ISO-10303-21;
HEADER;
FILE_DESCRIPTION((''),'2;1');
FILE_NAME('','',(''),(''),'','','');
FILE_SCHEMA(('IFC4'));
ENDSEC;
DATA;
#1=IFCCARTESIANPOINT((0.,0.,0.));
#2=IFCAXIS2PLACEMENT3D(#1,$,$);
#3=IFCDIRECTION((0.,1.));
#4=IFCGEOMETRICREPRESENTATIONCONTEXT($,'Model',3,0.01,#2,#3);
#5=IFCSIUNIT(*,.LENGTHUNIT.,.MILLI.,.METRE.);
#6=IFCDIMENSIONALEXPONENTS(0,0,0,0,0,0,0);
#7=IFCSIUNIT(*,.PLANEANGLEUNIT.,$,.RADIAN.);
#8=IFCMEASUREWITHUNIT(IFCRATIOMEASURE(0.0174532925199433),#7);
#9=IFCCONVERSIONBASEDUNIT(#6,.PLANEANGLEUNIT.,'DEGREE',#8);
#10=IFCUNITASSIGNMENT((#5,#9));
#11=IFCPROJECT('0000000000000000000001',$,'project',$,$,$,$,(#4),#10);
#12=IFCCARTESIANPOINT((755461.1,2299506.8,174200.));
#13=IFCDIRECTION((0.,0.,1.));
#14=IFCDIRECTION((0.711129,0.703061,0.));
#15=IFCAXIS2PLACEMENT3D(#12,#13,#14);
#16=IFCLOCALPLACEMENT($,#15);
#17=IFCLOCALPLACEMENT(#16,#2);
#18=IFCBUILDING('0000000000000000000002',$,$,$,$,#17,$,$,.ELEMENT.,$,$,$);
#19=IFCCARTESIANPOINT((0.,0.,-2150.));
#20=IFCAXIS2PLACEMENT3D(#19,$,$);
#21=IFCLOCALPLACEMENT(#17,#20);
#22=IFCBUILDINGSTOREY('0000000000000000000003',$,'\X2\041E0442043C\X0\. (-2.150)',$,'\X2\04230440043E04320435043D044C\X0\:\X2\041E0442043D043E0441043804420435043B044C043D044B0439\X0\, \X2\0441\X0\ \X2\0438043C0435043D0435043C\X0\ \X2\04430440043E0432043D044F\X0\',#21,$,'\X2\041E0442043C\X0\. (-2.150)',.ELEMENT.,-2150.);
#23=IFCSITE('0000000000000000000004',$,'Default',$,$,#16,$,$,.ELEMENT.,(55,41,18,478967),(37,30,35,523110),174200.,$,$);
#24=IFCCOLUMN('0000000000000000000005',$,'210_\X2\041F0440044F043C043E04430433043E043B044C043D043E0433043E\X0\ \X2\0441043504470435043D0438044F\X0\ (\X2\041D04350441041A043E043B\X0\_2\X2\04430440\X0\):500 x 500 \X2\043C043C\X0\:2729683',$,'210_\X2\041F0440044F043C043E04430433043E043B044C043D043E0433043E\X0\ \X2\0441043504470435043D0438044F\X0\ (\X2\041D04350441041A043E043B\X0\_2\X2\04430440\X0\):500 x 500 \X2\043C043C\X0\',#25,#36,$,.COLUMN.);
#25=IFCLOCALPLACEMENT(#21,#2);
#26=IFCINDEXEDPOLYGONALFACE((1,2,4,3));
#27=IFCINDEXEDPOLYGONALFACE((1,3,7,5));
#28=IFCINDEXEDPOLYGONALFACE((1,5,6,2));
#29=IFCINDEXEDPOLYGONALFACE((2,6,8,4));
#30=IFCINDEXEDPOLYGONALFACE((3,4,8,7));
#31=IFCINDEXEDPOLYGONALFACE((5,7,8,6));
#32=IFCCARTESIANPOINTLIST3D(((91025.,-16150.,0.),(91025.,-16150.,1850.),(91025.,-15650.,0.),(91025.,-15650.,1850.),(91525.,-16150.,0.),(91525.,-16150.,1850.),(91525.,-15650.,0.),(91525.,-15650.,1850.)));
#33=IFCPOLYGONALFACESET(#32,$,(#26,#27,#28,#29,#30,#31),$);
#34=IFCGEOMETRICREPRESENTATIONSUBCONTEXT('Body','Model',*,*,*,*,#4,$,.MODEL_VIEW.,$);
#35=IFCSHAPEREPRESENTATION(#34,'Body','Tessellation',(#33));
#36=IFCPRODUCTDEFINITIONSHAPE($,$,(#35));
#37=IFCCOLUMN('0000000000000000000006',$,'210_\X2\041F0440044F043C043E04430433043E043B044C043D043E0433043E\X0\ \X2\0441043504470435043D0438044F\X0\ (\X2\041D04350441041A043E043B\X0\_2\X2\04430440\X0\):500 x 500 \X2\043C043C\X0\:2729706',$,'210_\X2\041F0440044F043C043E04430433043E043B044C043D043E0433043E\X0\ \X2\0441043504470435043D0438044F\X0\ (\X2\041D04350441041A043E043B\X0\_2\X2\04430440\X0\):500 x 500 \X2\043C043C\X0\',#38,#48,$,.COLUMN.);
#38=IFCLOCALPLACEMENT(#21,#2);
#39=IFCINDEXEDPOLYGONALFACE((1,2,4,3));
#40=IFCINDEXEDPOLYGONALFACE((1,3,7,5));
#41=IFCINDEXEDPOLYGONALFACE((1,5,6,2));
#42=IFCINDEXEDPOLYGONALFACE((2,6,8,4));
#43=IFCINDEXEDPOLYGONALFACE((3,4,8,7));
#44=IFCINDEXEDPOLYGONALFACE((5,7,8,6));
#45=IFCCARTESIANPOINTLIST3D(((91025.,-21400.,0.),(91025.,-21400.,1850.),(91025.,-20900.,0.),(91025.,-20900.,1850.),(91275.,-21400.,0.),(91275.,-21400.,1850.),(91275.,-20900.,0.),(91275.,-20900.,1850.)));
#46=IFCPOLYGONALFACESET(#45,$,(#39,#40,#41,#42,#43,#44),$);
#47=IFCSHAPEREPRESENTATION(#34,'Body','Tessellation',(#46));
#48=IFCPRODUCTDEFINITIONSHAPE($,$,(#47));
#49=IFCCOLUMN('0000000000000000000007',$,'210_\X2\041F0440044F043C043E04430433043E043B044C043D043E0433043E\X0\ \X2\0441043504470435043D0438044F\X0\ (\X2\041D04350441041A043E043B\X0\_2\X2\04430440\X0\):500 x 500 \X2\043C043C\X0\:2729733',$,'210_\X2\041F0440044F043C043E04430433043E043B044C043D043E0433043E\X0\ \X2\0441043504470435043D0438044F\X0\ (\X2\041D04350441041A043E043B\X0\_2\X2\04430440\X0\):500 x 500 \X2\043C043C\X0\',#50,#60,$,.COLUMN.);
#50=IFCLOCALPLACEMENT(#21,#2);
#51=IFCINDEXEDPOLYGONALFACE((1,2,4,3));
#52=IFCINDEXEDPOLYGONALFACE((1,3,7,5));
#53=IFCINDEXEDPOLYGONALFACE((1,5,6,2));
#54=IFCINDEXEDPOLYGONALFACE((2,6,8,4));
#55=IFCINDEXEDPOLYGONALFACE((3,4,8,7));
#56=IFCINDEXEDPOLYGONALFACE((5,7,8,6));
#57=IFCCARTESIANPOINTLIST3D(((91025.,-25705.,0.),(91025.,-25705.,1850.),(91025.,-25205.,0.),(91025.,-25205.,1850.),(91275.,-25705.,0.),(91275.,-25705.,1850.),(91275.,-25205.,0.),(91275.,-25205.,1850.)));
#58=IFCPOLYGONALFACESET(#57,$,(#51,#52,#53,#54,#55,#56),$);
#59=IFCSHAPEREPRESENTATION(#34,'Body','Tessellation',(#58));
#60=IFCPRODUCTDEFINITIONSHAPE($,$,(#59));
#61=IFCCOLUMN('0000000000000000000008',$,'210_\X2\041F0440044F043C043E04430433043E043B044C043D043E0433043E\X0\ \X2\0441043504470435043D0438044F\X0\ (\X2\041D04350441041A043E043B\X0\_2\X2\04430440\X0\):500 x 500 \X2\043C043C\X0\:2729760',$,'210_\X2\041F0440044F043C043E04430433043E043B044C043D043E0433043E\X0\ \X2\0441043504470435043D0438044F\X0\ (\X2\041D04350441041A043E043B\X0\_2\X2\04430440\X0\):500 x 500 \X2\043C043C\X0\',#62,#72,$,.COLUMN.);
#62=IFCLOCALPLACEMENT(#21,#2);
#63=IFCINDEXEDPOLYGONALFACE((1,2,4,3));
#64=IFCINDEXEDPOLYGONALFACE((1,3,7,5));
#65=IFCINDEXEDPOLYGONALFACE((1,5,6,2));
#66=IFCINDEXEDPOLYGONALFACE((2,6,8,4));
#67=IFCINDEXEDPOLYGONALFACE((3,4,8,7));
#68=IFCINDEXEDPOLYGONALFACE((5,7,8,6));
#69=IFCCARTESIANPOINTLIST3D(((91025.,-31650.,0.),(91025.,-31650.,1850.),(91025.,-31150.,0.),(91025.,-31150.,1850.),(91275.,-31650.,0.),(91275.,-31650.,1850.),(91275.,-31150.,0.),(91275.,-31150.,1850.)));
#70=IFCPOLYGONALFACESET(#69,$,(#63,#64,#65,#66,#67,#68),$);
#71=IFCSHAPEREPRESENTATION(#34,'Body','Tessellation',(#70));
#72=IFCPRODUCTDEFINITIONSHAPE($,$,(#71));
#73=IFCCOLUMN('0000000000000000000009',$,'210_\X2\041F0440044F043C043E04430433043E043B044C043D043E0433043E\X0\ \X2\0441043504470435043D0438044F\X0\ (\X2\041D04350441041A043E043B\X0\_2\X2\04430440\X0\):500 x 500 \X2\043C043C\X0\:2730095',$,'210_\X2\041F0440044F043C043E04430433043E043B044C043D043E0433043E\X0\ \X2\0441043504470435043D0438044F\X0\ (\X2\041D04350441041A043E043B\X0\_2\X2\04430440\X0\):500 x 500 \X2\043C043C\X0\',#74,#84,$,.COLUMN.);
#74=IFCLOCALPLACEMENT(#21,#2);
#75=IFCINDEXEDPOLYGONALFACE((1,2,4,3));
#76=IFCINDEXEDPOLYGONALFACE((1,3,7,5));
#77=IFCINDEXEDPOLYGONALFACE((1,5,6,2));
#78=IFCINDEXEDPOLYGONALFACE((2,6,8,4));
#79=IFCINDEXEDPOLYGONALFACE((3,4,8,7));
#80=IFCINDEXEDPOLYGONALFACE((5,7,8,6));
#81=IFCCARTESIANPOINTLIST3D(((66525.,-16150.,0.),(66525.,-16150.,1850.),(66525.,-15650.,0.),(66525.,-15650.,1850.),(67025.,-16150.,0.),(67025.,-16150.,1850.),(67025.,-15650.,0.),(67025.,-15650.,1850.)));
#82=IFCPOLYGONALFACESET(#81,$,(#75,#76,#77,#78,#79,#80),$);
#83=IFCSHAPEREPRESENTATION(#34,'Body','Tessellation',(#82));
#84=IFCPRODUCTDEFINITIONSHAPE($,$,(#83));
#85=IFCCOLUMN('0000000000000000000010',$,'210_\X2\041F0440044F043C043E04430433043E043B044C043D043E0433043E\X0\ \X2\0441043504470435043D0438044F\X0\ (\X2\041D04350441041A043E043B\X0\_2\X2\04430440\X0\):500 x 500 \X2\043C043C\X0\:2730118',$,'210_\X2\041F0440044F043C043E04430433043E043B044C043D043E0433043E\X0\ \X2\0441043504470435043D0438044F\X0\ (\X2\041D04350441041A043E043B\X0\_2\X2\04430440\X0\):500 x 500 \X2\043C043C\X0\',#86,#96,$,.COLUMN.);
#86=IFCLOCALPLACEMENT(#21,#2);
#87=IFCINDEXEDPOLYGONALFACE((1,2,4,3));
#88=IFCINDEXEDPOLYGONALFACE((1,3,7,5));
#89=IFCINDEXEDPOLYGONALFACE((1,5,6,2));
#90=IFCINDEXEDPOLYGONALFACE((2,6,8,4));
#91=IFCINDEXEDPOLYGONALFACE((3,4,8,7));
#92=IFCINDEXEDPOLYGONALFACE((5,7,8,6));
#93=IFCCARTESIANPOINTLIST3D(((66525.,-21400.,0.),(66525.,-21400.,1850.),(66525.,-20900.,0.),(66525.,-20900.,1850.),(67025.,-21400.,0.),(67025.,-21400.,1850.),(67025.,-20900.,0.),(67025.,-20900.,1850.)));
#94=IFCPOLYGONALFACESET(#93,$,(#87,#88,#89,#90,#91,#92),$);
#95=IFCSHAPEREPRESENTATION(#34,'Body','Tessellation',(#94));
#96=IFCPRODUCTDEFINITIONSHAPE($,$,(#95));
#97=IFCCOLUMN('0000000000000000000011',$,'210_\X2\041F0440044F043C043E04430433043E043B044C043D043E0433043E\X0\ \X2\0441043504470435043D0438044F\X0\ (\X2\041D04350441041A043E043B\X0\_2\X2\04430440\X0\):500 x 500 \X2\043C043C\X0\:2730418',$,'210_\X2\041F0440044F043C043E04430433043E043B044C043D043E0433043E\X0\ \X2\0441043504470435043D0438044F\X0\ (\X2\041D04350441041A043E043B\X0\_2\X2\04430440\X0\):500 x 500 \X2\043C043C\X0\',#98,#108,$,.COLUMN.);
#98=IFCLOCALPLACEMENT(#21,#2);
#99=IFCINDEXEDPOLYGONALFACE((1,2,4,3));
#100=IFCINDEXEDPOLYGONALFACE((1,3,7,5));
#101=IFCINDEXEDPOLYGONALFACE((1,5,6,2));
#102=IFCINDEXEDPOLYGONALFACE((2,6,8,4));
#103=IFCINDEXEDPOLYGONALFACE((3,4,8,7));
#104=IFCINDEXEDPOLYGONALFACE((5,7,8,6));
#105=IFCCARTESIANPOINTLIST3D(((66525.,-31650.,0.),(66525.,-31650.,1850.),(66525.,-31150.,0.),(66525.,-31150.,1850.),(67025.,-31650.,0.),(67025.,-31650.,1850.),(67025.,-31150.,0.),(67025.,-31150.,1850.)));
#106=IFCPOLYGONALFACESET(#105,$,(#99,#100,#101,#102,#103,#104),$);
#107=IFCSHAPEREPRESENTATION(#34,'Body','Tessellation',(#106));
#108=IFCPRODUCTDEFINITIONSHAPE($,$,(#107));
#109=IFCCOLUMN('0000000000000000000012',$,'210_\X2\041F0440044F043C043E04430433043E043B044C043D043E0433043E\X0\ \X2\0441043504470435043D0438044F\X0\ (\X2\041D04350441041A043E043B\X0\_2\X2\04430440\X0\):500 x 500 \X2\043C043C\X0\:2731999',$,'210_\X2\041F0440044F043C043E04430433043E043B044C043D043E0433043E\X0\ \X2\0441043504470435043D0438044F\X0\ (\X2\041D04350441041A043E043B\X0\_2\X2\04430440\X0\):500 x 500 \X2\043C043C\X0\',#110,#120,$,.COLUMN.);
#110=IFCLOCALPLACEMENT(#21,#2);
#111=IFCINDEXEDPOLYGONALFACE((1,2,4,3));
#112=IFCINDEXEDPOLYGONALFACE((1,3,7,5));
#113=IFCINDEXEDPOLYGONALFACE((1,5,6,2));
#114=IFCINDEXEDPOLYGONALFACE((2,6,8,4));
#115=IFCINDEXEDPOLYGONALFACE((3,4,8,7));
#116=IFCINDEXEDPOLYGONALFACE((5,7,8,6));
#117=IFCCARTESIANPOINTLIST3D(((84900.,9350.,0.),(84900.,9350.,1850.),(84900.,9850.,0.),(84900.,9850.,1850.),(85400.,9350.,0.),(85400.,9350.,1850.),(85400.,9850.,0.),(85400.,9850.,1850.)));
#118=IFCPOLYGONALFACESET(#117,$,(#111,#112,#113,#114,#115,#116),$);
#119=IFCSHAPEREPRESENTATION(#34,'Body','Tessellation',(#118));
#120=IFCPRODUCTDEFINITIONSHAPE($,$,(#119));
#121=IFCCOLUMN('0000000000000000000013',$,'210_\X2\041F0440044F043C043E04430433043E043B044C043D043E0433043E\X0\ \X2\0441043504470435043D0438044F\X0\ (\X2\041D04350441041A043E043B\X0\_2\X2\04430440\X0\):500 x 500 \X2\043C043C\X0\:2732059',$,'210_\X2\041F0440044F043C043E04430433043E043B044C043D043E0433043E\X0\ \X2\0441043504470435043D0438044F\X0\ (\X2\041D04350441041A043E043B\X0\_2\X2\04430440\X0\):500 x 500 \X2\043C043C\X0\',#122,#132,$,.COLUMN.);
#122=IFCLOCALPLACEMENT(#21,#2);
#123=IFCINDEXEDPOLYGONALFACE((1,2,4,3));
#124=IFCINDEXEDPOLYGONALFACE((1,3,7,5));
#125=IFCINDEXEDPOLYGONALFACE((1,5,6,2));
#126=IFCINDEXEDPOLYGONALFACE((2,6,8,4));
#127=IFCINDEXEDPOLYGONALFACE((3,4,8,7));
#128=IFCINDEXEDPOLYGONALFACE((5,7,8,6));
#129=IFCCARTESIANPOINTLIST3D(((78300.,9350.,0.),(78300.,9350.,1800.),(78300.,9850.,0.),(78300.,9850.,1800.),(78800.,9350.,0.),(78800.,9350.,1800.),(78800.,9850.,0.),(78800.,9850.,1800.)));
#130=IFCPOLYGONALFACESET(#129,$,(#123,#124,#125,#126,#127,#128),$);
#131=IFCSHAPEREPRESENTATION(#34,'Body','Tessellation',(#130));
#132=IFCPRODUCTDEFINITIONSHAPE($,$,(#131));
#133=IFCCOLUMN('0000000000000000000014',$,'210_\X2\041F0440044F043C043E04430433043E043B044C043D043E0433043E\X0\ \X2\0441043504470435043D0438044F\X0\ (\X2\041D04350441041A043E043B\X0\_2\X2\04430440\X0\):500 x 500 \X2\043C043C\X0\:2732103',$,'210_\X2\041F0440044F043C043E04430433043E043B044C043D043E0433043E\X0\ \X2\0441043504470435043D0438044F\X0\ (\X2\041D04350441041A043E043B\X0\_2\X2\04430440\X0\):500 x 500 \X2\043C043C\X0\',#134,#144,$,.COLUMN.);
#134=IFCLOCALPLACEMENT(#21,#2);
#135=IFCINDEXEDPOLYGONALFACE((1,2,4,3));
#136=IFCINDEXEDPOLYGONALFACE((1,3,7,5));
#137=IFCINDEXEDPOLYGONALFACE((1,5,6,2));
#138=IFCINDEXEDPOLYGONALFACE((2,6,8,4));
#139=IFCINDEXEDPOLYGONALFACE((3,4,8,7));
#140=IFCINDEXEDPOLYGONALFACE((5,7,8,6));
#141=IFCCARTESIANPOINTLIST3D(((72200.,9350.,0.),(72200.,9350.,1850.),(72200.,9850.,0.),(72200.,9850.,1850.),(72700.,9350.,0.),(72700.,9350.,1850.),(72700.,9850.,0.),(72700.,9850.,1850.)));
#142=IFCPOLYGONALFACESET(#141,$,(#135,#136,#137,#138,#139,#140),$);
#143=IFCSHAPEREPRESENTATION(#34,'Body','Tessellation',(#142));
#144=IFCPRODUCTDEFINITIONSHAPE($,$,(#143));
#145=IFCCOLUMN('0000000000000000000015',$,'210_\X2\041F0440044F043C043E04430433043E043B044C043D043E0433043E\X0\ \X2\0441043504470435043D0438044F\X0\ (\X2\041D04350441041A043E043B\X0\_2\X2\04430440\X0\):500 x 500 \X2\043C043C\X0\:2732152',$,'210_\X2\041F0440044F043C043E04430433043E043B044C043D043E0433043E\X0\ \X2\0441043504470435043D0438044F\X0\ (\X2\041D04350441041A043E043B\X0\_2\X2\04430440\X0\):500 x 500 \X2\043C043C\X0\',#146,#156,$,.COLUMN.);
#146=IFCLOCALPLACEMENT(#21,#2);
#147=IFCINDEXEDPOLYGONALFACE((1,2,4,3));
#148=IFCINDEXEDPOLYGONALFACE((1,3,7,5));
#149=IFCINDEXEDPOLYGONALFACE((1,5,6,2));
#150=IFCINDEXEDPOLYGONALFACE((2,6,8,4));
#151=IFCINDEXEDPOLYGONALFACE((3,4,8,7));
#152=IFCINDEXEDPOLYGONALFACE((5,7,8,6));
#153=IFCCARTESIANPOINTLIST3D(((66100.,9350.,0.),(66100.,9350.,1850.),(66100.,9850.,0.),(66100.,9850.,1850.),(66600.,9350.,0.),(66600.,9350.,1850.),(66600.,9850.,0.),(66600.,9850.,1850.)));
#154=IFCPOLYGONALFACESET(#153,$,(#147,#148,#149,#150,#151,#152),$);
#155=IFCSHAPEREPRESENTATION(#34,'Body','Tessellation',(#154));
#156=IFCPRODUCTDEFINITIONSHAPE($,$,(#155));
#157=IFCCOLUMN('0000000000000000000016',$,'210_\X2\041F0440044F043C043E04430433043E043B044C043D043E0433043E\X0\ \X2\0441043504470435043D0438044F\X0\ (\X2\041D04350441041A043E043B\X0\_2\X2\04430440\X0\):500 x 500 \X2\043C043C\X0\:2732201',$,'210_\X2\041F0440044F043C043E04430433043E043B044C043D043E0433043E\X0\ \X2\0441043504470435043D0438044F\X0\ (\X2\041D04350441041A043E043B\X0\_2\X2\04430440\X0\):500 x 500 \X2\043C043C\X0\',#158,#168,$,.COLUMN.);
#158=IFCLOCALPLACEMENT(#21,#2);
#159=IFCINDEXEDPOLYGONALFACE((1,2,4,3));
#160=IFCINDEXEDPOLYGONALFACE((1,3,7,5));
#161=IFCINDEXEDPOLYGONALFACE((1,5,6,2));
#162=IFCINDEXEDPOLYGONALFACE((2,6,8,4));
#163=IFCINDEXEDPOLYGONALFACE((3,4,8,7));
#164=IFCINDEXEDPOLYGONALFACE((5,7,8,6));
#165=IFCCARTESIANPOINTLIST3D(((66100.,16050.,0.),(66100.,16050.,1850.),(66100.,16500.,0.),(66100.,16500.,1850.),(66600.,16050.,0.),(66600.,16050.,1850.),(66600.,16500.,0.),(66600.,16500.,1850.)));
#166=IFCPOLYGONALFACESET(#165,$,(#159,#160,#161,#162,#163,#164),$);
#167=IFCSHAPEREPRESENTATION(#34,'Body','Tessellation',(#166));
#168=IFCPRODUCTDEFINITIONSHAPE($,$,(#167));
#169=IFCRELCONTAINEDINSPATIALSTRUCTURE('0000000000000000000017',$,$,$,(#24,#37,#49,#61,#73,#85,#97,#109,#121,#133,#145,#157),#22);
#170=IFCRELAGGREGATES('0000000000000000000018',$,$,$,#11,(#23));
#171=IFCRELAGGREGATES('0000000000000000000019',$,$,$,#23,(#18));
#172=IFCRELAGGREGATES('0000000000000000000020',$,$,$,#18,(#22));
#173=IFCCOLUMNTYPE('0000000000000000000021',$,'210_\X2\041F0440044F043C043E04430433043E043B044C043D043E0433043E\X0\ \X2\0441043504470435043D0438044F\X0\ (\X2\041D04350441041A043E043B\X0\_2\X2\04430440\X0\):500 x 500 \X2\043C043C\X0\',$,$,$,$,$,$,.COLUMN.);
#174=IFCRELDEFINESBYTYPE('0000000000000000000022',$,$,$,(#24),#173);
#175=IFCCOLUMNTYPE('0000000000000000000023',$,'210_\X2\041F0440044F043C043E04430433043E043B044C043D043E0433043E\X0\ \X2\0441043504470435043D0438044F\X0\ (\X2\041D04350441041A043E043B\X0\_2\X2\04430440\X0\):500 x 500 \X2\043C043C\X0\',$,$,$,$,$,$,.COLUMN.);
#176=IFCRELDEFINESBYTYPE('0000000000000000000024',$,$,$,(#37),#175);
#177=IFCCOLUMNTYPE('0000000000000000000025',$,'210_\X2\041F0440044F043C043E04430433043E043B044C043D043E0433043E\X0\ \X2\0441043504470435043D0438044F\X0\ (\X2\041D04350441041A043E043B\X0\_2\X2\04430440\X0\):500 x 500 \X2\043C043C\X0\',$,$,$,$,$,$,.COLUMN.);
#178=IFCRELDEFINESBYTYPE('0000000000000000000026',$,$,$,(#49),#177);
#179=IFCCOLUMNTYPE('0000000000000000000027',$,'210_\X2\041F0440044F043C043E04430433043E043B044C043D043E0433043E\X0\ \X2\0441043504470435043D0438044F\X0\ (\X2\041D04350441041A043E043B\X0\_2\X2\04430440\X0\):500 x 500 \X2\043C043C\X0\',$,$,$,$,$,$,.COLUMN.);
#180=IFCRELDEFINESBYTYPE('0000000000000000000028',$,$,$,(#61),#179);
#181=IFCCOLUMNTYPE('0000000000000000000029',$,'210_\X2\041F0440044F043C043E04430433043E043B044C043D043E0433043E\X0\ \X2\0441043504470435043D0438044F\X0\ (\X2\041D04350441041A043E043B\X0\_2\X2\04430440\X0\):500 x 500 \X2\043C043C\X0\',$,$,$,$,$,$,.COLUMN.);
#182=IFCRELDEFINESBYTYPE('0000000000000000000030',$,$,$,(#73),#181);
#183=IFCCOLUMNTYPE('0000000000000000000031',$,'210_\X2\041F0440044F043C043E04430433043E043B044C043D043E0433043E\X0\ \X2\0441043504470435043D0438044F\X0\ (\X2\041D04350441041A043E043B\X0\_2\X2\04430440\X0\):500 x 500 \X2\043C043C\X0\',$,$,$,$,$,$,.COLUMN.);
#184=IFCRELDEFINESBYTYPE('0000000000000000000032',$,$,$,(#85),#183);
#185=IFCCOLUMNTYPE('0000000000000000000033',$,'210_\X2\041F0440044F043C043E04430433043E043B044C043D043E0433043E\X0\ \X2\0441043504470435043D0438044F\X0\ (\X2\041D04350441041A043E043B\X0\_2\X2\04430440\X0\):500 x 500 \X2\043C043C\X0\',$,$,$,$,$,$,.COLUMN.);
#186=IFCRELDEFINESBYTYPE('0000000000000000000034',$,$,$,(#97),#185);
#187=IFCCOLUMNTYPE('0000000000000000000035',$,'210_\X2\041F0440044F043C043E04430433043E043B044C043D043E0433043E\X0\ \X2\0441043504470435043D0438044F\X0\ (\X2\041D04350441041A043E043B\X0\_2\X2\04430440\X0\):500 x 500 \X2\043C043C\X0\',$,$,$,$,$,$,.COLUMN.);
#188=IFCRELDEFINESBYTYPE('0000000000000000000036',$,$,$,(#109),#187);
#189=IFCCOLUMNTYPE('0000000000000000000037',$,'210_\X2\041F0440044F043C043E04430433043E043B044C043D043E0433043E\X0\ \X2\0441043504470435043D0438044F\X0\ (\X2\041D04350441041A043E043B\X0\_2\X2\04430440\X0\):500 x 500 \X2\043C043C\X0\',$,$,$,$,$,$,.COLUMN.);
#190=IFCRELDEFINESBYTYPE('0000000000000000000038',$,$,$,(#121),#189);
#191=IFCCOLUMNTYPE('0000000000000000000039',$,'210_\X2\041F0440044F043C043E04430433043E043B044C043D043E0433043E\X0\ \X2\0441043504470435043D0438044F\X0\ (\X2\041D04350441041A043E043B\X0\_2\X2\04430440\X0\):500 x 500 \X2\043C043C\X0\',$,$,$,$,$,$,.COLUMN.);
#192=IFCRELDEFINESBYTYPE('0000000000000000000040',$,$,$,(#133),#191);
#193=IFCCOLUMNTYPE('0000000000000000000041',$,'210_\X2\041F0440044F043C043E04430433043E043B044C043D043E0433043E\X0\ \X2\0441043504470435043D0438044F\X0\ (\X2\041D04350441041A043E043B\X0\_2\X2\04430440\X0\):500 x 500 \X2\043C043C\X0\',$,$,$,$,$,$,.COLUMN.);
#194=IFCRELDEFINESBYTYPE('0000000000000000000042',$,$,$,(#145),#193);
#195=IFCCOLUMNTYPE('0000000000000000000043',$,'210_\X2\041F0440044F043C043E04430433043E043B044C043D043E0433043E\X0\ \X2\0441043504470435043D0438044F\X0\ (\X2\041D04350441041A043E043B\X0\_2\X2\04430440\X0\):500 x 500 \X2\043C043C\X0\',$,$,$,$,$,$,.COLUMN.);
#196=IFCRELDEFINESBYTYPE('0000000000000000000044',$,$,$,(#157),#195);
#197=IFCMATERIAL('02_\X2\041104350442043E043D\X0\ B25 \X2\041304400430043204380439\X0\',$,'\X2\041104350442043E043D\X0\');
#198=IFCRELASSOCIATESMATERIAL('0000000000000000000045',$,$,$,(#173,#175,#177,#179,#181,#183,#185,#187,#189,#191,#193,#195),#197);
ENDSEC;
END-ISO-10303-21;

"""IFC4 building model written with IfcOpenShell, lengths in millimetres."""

from ifc_helpers import new_model, entity, si_unit, converted_unit, direction, frame, origin, place, context, subcontext, project, spatial, indexed_curve, outline, extrude, source, transform, mapped, material, type_object, type_shapes, element, save


model = new_model("IFC4")

# Units and contexts
model_context = context("Model", 3, precision=0.01, world=origin(), true_north=direction((0.0, 1.0)))
body_context = subcontext(model_context, "Body", "Model", "MODEL_VIEW")
ifc_project = project(units=[si_unit("LENGTHUNIT", "METRE", prefix="MILLI"), converted_unit("PLANEANGLEUNIT", "DEGREE", entity("IfcRatioMeasure", 0.0174532925199433), si_unit("PLANEANGLEUNIT", "RADIAN"), dimensions=[0, 0, 0, 0, 0, 0, 0])], contexts=[model_context])

# Site, building, storey
site_placement = place(None, frame((755461.1, 2299506.8, 174200.0), z_axis=(0.0, 0.0, 1.0), x_axis=(0.711129, 0.703061, 0.0)))
site = spatial("IfcSite", under=ifc_project, at=site_placement, Name="Default", CompositionType="ELEMENT", RefLatitude=(55, 41, 18, 478967), RefLongitude=(37, 30, 35, 523110), RefElevation=174200.0)
building_placement = place(site_placement, origin())
building = spatial("IfcBuilding", under=site, at=building_placement, CompositionType="ELEMENT")
storey_placement = place(building_placement, frame((0.0, 0.0, -2150.0)))
storey = spatial("IfcBuildingStorey", under=building, at=storey_placement, Name="Отм. (-2.150)", ObjectType="Уровень:Относительный, с именем уровня", LongName="Отм. (-2.150)", CompositionType="ELEMENT", Elevation=-2150.0)

# Columns
ifc_material_1 = material(Name="02_Бетон B25 Гравий", Category="Бетон")
column_type_1 = type_object("IfcColumnType", Name="210_Прямоугольного сечения (НесКол_2ур):500 x 500 мм", PredefinedType="COLUMN", material=ifc_material_1)
shared_shape_1 = source(origin(), body_context, "Body", "SweptSolid", [
    extrude(outline(indexed_curve([(-250.0, -250.0), (250.0, -250.0), (250.0, 250.0), (-250.0, 250.0), (-250.0, -250.0)], self_intersect=False)), frame((91275.0, -15900.0, -2150.0), z_axis=(0.0, 0.0, 1.0), x_axis=(0.0, -1.0, 0.0)), (0.0, 0.0, 1.0), 1850.0),
])
type_shapes(column_type_1, [shared_shape_1])
column_1_placement = place(storey_placement, frame((0.0, 0.0, 2150.0)))
element("IfcColumn", 1, at=column_1_placement, inside=storey, type_object=column_type_1, Name="210_Прямоугольного сечения (НесКол_2ур):500 x 500 мм:2729683", ObjectType="210_Прямоугольного сечения (НесКол_2ур):500 x 500 мм", PredefinedType="COLUMN", context=body_context, shape_type="MappedRepresentation", body=[
    mapped(shared_shape_1, transform((0.0, 0.0, 0.0), scale=1.0)),
])
column_type_2 = type_object("IfcColumnType", Name="210_Прямоугольного сечения (НесКол_2ур):500 x 500 мм", PredefinedType="COLUMN", material=ifc_material_1)
shared_shape_2 = source(origin(), body_context, "Body", "SweptSolid", [
    extrude(outline(indexed_curve([(-250.0, -125.0), (250.0, -125.0), (250.0, 125.0), (-250.0, 125.0), (-250.0, -125.0)], self_intersect=False)), frame((91150.0, -21150.0, -2150.0), z_axis=(0.0, 0.0, 1.0), x_axis=(0.0, -1.0, 0.0)), (0.0, 0.0, 1.0), 1850.0),
])
type_shapes(column_type_2, [shared_shape_2])
column_2_placement = place(storey_placement, frame((0.0, 0.0, 2150.0)))
element("IfcColumn", 2, at=column_2_placement, inside=storey, type_object=column_type_2, Name="210_Прямоугольного сечения (НесКол_2ур):500 x 500 мм:2729706", ObjectType="210_Прямоугольного сечения (НесКол_2ур):500 x 500 мм", PredefinedType="COLUMN", context=body_context, shape_type="MappedRepresentation", body=[
    mapped(shared_shape_2, transform((0.0, 0.0, 0.0), scale=1.0)),
])
column_type_3 = type_object("IfcColumnType", Name="210_Прямоугольного сечения (НесКол_2ур):500 x 500 мм", PredefinedType="COLUMN", material=ifc_material_1)
shared_shape_3 = source(origin(), body_context, "Body", "SweptSolid", [
    extrude(outline(indexed_curve([(-250.0, -125.0), (250.0, -125.0), (250.0, 125.0), (-250.0, 125.0), (-250.0, -125.0)], self_intersect=False)), frame((91150.0, -25455.0, -2150.0), z_axis=(0.0, 0.0, 1.0), x_axis=(0.0, -1.0, 0.0)), (0.0, 0.0, 1.0), 1850.0),
])
type_shapes(column_type_3, [shared_shape_3])
column_3_placement = place(storey_placement, frame((0.0, 0.0, 2150.0)))
element("IfcColumn", 3, at=column_3_placement, inside=storey, type_object=column_type_3, Name="210_Прямоугольного сечения (НесКол_2ур):500 x 500 мм:2729733", ObjectType="210_Прямоугольного сечения (НесКол_2ур):500 x 500 мм", PredefinedType="COLUMN", context=body_context, shape_type="MappedRepresentation", body=[
    mapped(shared_shape_3, transform((0.0, 0.0, 0.0), scale=1.0)),
])
column_type_4 = type_object("IfcColumnType", Name="210_Прямоугольного сечения (НесКол_2ур):500 x 500 мм", PredefinedType="COLUMN", material=ifc_material_1)
shared_shape_4 = source(origin(), body_context, "Body", "SweptSolid", [
    extrude(outline(indexed_curve([(-250.0, -125.0), (250.0, -125.0), (250.0, 125.0), (-250.0, 125.0), (-250.0, -125.0)], self_intersect=False)), frame((91150.0, -31400.0, -2150.0), z_axis=(0.0, 0.0, 1.0), x_axis=(0.0, -1.0, 0.0)), (0.0, 0.0, 1.0), 1850.0),
])
type_shapes(column_type_4, [shared_shape_4])
column_4_placement = place(storey_placement, frame((0.0, 0.0, 2150.0)))
element("IfcColumn", 4, at=column_4_placement, inside=storey, type_object=column_type_4, Name="210_Прямоугольного сечения (НесКол_2ур):500 x 500 мм:2729760", ObjectType="210_Прямоугольного сечения (НесКол_2ур):500 x 500 мм", PredefinedType="COLUMN", context=body_context, shape_type="MappedRepresentation", body=[
    mapped(shared_shape_4, transform((0.0, 0.0, 0.0), scale=1.0)),
])
column_type_5 = type_object("IfcColumnType", Name="210_Прямоугольного сечения (НесКол_2ур):500 x 500 мм", PredefinedType="COLUMN", material=ifc_material_1)
shared_shape_5 = source(origin(), body_context, "Body", "SweptSolid", [
    extrude(outline(indexed_curve([(-250.0, -250.0), (250.0, -250.0), (250.0, 250.0), (-250.0, 250.0), (-250.0, -250.0)], self_intersect=False)), frame((66775.0, -15900.0, -2150.0), z_axis=(0.0, 0.0, 1.0), x_axis=(0.0, -1.0, 0.0)), (0.0, 0.0, 1.0), 1850.0),
])
type_shapes(column_type_5, [shared_shape_5])
column_5_placement = place(storey_placement, frame((0.0, 0.0, 2150.0)))
element("IfcColumn", 5, at=column_5_placement, inside=storey, type_object=column_type_5, Name="210_Прямоугольного сечения (НесКол_2ур):500 x 500 мм:2730095", ObjectType="210_Прямоугольного сечения (НесКол_2ур):500 x 500 мм", PredefinedType="COLUMN", context=body_context, shape_type="MappedRepresentation", body=[
    mapped(shared_shape_5, transform((0.0, 0.0, 0.0), scale=1.0)),
])
column_type_6 = type_object("IfcColumnType", Name="210_Прямоугольного сечения (НесКол_2ур):500 x 500 мм", PredefinedType="COLUMN", material=ifc_material_1)
shared_shape_6 = source(origin(), body_context, "Body", "SweptSolid", [
    extrude(outline(indexed_curve([(-250.0, -250.0), (250.0, -250.0), (250.0, 250.0), (-250.0, 250.0), (-250.0, -250.0)], self_intersect=False)), frame((66775.0, -21150.0, -2150.0), z_axis=(0.0, 0.0, 1.0), x_axis=(0.0, -1.0, 0.0)), (0.0, 0.0, 1.0), 1850.0),
])
type_shapes(column_type_6, [shared_shape_6])
column_6_placement = place(storey_placement, frame((0.0, 0.0, 2150.0)))
element("IfcColumn", 6, at=column_6_placement, inside=storey, type_object=column_type_6, Name="210_Прямоугольного сечения (НесКол_2ур):500 x 500 мм:2730118", ObjectType="210_Прямоугольного сечения (НесКол_2ур):500 x 500 мм", PredefinedType="COLUMN", context=body_context, shape_type="MappedRepresentation", body=[
    mapped(shared_shape_6, transform((0.0, 0.0, 0.0), scale=1.0)),
])
column_type_7 = type_object("IfcColumnType", Name="210_Прямоугольного сечения (НесКол_2ур):500 x 500 мм", PredefinedType="COLUMN", material=ifc_material_1)
shared_shape_7 = source(origin(), body_context, "Body", "SweptSolid", [
    extrude(outline(indexed_curve([(-250.0, -250.0), (250.0, -250.0), (250.0, 250.0), (-250.0, 250.0), (-250.0, -250.0)], self_intersect=False)), frame((66775.0, -31400.0, -2150.0), z_axis=(0.0, 0.0, 1.0), x_axis=(0.0, -1.0, 0.0)), (0.0, 0.0, 1.0), 1850.0),
])
type_shapes(column_type_7, [shared_shape_7])
column_7_placement = place(storey_placement, frame((0.0, 0.0, 2150.0)))
element("IfcColumn", 7, at=column_7_placement, inside=storey, type_object=column_type_7, Name="210_Прямоугольного сечения (НесКол_2ур):500 x 500 мм:2730418", ObjectType="210_Прямоугольного сечения (НесКол_2ур):500 x 500 мм", PredefinedType="COLUMN", context=body_context, shape_type="MappedRepresentation", body=[
    mapped(shared_shape_7, transform((0.0, 0.0, 0.0), scale=1.0)),
])
column_type_8 = type_object("IfcColumnType", Name="210_Прямоугольного сечения (НесКол_2ур):500 x 500 мм", PredefinedType="COLUMN", material=ifc_material_1)
shared_shape_8 = source(origin(), body_context, "Body", "SweptSolid", [
    extrude(outline(indexed_curve([(-250.0, -250.0), (250.0, -250.0), (250.0, 250.0), (-250.0, 250.0), (-250.0, -250.0)], self_intersect=False)), frame((85150.0, 9600.0, -2150.0), z_axis=(0.0, 0.0, 1.0), x_axis=(0.0, -1.0, 0.0)), (0.0, 0.0, 1.0), 1850.0),
])
type_shapes(column_type_8, [shared_shape_8])
column_8_placement = place(storey_placement, frame((0.0, 0.0, 2150.0)))
element("IfcColumn", 8, at=column_8_placement, inside=storey, type_object=column_type_8, Name="210_Прямоугольного сечения (НесКол_2ур):500 x 500 мм:2731999", ObjectType="210_Прямоугольного сечения (НесКол_2ур):500 x 500 мм", PredefinedType="COLUMN", context=body_context, shape_type="MappedRepresentation", body=[
    mapped(shared_shape_8, transform((0.0, 0.0, 0.0), scale=1.0)),
])
column_type_9 = type_object("IfcColumnType", Name="210_Прямоугольного сечения (НесКол_2ур):500 x 500 мм", PredefinedType="COLUMN", material=ifc_material_1)
shared_shape_9 = source(origin(), body_context, "Body", "SweptSolid", [
    extrude(outline(indexed_curve([(-250.0, -250.0), (250.0, -250.0), (250.0, 250.0), (-250.0, 250.0), (-250.0, -250.0)], self_intersect=False)), frame((78550.0, 9600.0, -2150.0), z_axis=(0.0, 0.0, 1.0), x_axis=(0.0, -1.0, 0.0)), (0.0, 0.0, 1.0), 1800.0),
])
type_shapes(column_type_9, [shared_shape_9])
column_9_placement = place(storey_placement, frame((0.0, 0.0, 2150.0)))
element("IfcColumn", 9, at=column_9_placement, inside=storey, type_object=column_type_9, Name="210_Прямоугольного сечения (НесКол_2ур):500 x 500 мм:2732059", ObjectType="210_Прямоугольного сечения (НесКол_2ур):500 x 500 мм", PredefinedType="COLUMN", context=body_context, shape_type="MappedRepresentation", body=[
    mapped(shared_shape_9, transform((0.0, 0.0, 0.0), scale=1.0)),
])
column_type_10 = type_object("IfcColumnType", Name="210_Прямоугольного сечения (НесКол_2ур):500 x 500 мм", PredefinedType="COLUMN", material=ifc_material_1)
shared_shape_10 = source(origin(), body_context, "Body", "SweptSolid", [
    extrude(outline(indexed_curve([(-250.0, -250.0), (250.0, -250.0), (250.0, 250.0), (-250.0, 250.0), (-250.0, -250.0)], self_intersect=False)), frame((72450.0, 9600.0, -2150.0), z_axis=(0.0, 0.0, 1.0), x_axis=(0.0, -1.0, 0.0)), (0.0, 0.0, 1.0), 1850.0),
])
type_shapes(column_type_10, [shared_shape_10])
column_10_placement = place(storey_placement, frame((0.0, 0.0, 2150.0)))
element("IfcColumn", 10, at=column_10_placement, inside=storey, type_object=column_type_10, Name="210_Прямоугольного сечения (НесКол_2ур):500 x 500 мм:2732103", ObjectType="210_Прямоугольного сечения (НесКол_2ур):500 x 500 мм", PredefinedType="COLUMN", context=body_context, shape_type="MappedRepresentation", body=[
    mapped(shared_shape_10, transform((0.0, 0.0, 0.0), scale=1.0)),
])
column_type_11 = type_object("IfcColumnType", Name="210_Прямоугольного сечения (НесКол_2ур):500 x 500 мм", PredefinedType="COLUMN", material=ifc_material_1)
shared_shape_11 = source(origin(), body_context, "Body", "SweptSolid", [
    extrude(outline(indexed_curve([(-250.0, -250.0), (250.0, -250.0), (250.0, 250.0), (-250.0, 250.0), (-250.0, -250.0)], self_intersect=False)), frame((66350.0, 9600.0, -2150.0), z_axis=(0.0, 0.0, 1.0), x_axis=(0.0, -1.0, 0.0)), (0.0, 0.0, 1.0), 1850.0),
])
type_shapes(column_type_11, [shared_shape_11])
column_11_placement = place(storey_placement, frame((0.0, 0.0, 2150.0)))
element("IfcColumn", 11, at=column_11_placement, inside=storey, type_object=column_type_11, Name="210_Прямоугольного сечения (НесКол_2ур):500 x 500 мм:2732152", ObjectType="210_Прямоугольного сечения (НесКол_2ур):500 x 500 мм", PredefinedType="COLUMN", context=body_context, shape_type="MappedRepresentation", body=[
    mapped(shared_shape_11, transform((0.0, 0.0, 0.0), scale=1.0)),
])
column_type_12 = type_object("IfcColumnType", Name="210_Прямоугольного сечения (НесКол_2ур):500 x 500 мм", PredefinedType="COLUMN", material=ifc_material_1)
shared_shape_12 = source(origin(), body_context, "Body", "SweptSolid", [
    extrude(outline(indexed_curve([(-225.0, -250.0), (225.0, -250.0), (225.0, 250.0), (-225.0, 250.0), (-225.0, -250.0)], self_intersect=False)), frame((66350.0, 16275.0, -2150.0), z_axis=(0.0, 0.0, 1.0), x_axis=(0.0, -1.0, 0.0)), (0.0, 0.0, 1.0), 1850.0),
])
type_shapes(column_type_12, [shared_shape_12])
column_12_placement = place(storey_placement, frame((0.0, 0.0, 2150.0)))
element("IfcColumn", 12, at=column_12_placement, inside=storey, type_object=column_type_12, Name="210_Прямоугольного сечения (НесКол_2ур):500 x 500 мм:2732201", ObjectType="210_Прямоугольного сечения (НесКол_2ур):500 x 500 мм", PredefinedType="COLUMN", context=body_context, shape_type="MappedRepresentation", body=[
    mapped(shared_shape_12, transform((0.0, 0.0, 0.0), scale=1.0)),
])

save(model, "model.ifc")
